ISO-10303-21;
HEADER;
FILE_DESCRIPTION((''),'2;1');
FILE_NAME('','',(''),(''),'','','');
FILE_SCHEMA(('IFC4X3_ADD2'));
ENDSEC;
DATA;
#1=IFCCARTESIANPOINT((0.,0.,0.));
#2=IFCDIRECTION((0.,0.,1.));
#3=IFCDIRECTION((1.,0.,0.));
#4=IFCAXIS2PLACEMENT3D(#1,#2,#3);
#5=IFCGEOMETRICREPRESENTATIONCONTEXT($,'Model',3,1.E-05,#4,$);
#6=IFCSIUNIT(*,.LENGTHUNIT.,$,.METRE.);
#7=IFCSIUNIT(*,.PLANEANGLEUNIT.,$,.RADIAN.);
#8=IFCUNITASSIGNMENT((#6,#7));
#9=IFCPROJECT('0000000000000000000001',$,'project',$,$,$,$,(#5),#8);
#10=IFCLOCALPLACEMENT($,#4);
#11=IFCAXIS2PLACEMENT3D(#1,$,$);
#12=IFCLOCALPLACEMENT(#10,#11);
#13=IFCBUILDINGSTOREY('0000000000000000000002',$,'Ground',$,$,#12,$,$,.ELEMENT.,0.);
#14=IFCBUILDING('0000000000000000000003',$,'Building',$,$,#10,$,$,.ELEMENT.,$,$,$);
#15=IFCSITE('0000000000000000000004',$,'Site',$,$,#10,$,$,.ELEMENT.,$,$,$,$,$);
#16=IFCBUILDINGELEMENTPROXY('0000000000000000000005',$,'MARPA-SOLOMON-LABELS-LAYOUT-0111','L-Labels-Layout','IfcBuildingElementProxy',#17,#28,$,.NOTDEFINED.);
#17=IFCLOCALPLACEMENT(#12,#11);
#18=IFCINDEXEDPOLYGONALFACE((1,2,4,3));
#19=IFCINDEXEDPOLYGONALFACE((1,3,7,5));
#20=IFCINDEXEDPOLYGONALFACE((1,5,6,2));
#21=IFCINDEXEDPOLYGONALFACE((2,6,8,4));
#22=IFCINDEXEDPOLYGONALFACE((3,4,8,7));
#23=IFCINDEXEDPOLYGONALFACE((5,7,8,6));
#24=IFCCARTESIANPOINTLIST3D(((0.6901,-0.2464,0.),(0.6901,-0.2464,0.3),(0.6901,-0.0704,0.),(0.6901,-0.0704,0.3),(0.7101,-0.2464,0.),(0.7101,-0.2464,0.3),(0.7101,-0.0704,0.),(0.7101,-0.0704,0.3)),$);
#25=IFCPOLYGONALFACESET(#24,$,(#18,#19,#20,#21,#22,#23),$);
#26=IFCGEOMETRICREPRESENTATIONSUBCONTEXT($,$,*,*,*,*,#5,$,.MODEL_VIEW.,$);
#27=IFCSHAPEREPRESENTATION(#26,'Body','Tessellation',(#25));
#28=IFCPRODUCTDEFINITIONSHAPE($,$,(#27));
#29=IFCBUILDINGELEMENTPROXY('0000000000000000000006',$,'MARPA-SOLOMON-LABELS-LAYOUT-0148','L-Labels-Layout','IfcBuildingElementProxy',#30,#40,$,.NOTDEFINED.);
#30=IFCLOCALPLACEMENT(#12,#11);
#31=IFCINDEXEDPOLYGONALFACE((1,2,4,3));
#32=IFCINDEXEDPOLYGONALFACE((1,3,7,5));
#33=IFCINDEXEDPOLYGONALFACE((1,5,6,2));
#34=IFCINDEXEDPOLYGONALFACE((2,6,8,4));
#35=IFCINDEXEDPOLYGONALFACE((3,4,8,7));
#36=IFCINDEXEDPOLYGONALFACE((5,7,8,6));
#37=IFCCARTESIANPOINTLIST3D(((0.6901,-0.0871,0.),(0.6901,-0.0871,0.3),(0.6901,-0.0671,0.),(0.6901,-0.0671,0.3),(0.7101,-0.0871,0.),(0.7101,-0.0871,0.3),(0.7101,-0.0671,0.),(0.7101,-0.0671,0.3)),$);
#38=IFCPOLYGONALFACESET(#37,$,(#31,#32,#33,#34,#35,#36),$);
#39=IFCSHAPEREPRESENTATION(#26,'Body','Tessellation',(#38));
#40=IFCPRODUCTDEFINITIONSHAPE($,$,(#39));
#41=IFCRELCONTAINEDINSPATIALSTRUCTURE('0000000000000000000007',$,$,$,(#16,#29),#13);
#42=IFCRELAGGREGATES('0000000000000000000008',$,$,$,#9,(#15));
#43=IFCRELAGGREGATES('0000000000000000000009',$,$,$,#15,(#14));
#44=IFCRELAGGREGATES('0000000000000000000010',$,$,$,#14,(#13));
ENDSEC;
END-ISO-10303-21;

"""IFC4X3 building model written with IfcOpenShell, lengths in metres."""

from ifc_helpers import new_model, si_unit, frame, frame_2d, origin, origin_with_axes, place, context, subcontext, project, spatial, rectangle, extrude, element, save


model = new_model("IFC4X3")

# Units and contexts
model_context = context("Model", 3, precision=1e-05, world=origin_with_axes())
sub_context = subcontext(model_context, None, None, "MODEL_VIEW")
ifc_project = project(units=[si_unit("LENGTHUNIT", "METRE"), si_unit("PLANEANGLEUNIT", "RADIAN")], contexts=[model_context])

# Site, building, storey
placement = place(None, origin_with_axes())
site = spatial("IfcSite", under=ifc_project, at=placement, Name="Site", CompositionType="ELEMENT")
building = spatial("IfcBuilding", under=site, at=placement, Name="Building", CompositionType="ELEMENT")
storey_placement = place(placement, origin())
storey = spatial("IfcBuildingStorey", under=building, at=storey_placement, Name="Ground", CompositionType="ELEMENT", Elevation=0.0)

# Building element proxies
proxy_1_placement = place(placement, frame((0.6901, -0.2464, 0.0)))
element("IfcBuildingElementProxy", 1, at=proxy_1_placement, inside=storey, Name="MARPA-SOLOMON-LABELS-LAYOUT-0111", Description="L-Labels-Layout", ObjectType="IfcBuildingElementProxy", PredefinedType="NOTDEFINED", context=sub_context, shape_type="SweptSolid", body=[
    extrude(rectangle(XDim=0.02, YDim=0.176, at=frame_2d((0.01, 0.088))), origin(), (0.0, 0.0, 1.0), 0.3),
])
for number, where, name in (
    (2, (0.6901, -0.0871, 0.0), "MARPA-SOLOMON-LABELS-LAYOUT-0148"),
):
    element("IfcBuildingElementProxy", number, at=place(placement, frame(where)), inside=storey, Name=name, Description="L-Labels-Layout", ObjectType="IfcBuildingElementProxy", PredefinedType="NOTDEFINED", context=sub_context, shape_type="SweptSolid", body=[
        extrude(rectangle(XDim=0.02, YDim=0.02, at=frame_2d((0.01, 0.01))), origin(), (0.0, 0.0, 1.0), 0.3),
    ])

save(model, "model.ifc")
